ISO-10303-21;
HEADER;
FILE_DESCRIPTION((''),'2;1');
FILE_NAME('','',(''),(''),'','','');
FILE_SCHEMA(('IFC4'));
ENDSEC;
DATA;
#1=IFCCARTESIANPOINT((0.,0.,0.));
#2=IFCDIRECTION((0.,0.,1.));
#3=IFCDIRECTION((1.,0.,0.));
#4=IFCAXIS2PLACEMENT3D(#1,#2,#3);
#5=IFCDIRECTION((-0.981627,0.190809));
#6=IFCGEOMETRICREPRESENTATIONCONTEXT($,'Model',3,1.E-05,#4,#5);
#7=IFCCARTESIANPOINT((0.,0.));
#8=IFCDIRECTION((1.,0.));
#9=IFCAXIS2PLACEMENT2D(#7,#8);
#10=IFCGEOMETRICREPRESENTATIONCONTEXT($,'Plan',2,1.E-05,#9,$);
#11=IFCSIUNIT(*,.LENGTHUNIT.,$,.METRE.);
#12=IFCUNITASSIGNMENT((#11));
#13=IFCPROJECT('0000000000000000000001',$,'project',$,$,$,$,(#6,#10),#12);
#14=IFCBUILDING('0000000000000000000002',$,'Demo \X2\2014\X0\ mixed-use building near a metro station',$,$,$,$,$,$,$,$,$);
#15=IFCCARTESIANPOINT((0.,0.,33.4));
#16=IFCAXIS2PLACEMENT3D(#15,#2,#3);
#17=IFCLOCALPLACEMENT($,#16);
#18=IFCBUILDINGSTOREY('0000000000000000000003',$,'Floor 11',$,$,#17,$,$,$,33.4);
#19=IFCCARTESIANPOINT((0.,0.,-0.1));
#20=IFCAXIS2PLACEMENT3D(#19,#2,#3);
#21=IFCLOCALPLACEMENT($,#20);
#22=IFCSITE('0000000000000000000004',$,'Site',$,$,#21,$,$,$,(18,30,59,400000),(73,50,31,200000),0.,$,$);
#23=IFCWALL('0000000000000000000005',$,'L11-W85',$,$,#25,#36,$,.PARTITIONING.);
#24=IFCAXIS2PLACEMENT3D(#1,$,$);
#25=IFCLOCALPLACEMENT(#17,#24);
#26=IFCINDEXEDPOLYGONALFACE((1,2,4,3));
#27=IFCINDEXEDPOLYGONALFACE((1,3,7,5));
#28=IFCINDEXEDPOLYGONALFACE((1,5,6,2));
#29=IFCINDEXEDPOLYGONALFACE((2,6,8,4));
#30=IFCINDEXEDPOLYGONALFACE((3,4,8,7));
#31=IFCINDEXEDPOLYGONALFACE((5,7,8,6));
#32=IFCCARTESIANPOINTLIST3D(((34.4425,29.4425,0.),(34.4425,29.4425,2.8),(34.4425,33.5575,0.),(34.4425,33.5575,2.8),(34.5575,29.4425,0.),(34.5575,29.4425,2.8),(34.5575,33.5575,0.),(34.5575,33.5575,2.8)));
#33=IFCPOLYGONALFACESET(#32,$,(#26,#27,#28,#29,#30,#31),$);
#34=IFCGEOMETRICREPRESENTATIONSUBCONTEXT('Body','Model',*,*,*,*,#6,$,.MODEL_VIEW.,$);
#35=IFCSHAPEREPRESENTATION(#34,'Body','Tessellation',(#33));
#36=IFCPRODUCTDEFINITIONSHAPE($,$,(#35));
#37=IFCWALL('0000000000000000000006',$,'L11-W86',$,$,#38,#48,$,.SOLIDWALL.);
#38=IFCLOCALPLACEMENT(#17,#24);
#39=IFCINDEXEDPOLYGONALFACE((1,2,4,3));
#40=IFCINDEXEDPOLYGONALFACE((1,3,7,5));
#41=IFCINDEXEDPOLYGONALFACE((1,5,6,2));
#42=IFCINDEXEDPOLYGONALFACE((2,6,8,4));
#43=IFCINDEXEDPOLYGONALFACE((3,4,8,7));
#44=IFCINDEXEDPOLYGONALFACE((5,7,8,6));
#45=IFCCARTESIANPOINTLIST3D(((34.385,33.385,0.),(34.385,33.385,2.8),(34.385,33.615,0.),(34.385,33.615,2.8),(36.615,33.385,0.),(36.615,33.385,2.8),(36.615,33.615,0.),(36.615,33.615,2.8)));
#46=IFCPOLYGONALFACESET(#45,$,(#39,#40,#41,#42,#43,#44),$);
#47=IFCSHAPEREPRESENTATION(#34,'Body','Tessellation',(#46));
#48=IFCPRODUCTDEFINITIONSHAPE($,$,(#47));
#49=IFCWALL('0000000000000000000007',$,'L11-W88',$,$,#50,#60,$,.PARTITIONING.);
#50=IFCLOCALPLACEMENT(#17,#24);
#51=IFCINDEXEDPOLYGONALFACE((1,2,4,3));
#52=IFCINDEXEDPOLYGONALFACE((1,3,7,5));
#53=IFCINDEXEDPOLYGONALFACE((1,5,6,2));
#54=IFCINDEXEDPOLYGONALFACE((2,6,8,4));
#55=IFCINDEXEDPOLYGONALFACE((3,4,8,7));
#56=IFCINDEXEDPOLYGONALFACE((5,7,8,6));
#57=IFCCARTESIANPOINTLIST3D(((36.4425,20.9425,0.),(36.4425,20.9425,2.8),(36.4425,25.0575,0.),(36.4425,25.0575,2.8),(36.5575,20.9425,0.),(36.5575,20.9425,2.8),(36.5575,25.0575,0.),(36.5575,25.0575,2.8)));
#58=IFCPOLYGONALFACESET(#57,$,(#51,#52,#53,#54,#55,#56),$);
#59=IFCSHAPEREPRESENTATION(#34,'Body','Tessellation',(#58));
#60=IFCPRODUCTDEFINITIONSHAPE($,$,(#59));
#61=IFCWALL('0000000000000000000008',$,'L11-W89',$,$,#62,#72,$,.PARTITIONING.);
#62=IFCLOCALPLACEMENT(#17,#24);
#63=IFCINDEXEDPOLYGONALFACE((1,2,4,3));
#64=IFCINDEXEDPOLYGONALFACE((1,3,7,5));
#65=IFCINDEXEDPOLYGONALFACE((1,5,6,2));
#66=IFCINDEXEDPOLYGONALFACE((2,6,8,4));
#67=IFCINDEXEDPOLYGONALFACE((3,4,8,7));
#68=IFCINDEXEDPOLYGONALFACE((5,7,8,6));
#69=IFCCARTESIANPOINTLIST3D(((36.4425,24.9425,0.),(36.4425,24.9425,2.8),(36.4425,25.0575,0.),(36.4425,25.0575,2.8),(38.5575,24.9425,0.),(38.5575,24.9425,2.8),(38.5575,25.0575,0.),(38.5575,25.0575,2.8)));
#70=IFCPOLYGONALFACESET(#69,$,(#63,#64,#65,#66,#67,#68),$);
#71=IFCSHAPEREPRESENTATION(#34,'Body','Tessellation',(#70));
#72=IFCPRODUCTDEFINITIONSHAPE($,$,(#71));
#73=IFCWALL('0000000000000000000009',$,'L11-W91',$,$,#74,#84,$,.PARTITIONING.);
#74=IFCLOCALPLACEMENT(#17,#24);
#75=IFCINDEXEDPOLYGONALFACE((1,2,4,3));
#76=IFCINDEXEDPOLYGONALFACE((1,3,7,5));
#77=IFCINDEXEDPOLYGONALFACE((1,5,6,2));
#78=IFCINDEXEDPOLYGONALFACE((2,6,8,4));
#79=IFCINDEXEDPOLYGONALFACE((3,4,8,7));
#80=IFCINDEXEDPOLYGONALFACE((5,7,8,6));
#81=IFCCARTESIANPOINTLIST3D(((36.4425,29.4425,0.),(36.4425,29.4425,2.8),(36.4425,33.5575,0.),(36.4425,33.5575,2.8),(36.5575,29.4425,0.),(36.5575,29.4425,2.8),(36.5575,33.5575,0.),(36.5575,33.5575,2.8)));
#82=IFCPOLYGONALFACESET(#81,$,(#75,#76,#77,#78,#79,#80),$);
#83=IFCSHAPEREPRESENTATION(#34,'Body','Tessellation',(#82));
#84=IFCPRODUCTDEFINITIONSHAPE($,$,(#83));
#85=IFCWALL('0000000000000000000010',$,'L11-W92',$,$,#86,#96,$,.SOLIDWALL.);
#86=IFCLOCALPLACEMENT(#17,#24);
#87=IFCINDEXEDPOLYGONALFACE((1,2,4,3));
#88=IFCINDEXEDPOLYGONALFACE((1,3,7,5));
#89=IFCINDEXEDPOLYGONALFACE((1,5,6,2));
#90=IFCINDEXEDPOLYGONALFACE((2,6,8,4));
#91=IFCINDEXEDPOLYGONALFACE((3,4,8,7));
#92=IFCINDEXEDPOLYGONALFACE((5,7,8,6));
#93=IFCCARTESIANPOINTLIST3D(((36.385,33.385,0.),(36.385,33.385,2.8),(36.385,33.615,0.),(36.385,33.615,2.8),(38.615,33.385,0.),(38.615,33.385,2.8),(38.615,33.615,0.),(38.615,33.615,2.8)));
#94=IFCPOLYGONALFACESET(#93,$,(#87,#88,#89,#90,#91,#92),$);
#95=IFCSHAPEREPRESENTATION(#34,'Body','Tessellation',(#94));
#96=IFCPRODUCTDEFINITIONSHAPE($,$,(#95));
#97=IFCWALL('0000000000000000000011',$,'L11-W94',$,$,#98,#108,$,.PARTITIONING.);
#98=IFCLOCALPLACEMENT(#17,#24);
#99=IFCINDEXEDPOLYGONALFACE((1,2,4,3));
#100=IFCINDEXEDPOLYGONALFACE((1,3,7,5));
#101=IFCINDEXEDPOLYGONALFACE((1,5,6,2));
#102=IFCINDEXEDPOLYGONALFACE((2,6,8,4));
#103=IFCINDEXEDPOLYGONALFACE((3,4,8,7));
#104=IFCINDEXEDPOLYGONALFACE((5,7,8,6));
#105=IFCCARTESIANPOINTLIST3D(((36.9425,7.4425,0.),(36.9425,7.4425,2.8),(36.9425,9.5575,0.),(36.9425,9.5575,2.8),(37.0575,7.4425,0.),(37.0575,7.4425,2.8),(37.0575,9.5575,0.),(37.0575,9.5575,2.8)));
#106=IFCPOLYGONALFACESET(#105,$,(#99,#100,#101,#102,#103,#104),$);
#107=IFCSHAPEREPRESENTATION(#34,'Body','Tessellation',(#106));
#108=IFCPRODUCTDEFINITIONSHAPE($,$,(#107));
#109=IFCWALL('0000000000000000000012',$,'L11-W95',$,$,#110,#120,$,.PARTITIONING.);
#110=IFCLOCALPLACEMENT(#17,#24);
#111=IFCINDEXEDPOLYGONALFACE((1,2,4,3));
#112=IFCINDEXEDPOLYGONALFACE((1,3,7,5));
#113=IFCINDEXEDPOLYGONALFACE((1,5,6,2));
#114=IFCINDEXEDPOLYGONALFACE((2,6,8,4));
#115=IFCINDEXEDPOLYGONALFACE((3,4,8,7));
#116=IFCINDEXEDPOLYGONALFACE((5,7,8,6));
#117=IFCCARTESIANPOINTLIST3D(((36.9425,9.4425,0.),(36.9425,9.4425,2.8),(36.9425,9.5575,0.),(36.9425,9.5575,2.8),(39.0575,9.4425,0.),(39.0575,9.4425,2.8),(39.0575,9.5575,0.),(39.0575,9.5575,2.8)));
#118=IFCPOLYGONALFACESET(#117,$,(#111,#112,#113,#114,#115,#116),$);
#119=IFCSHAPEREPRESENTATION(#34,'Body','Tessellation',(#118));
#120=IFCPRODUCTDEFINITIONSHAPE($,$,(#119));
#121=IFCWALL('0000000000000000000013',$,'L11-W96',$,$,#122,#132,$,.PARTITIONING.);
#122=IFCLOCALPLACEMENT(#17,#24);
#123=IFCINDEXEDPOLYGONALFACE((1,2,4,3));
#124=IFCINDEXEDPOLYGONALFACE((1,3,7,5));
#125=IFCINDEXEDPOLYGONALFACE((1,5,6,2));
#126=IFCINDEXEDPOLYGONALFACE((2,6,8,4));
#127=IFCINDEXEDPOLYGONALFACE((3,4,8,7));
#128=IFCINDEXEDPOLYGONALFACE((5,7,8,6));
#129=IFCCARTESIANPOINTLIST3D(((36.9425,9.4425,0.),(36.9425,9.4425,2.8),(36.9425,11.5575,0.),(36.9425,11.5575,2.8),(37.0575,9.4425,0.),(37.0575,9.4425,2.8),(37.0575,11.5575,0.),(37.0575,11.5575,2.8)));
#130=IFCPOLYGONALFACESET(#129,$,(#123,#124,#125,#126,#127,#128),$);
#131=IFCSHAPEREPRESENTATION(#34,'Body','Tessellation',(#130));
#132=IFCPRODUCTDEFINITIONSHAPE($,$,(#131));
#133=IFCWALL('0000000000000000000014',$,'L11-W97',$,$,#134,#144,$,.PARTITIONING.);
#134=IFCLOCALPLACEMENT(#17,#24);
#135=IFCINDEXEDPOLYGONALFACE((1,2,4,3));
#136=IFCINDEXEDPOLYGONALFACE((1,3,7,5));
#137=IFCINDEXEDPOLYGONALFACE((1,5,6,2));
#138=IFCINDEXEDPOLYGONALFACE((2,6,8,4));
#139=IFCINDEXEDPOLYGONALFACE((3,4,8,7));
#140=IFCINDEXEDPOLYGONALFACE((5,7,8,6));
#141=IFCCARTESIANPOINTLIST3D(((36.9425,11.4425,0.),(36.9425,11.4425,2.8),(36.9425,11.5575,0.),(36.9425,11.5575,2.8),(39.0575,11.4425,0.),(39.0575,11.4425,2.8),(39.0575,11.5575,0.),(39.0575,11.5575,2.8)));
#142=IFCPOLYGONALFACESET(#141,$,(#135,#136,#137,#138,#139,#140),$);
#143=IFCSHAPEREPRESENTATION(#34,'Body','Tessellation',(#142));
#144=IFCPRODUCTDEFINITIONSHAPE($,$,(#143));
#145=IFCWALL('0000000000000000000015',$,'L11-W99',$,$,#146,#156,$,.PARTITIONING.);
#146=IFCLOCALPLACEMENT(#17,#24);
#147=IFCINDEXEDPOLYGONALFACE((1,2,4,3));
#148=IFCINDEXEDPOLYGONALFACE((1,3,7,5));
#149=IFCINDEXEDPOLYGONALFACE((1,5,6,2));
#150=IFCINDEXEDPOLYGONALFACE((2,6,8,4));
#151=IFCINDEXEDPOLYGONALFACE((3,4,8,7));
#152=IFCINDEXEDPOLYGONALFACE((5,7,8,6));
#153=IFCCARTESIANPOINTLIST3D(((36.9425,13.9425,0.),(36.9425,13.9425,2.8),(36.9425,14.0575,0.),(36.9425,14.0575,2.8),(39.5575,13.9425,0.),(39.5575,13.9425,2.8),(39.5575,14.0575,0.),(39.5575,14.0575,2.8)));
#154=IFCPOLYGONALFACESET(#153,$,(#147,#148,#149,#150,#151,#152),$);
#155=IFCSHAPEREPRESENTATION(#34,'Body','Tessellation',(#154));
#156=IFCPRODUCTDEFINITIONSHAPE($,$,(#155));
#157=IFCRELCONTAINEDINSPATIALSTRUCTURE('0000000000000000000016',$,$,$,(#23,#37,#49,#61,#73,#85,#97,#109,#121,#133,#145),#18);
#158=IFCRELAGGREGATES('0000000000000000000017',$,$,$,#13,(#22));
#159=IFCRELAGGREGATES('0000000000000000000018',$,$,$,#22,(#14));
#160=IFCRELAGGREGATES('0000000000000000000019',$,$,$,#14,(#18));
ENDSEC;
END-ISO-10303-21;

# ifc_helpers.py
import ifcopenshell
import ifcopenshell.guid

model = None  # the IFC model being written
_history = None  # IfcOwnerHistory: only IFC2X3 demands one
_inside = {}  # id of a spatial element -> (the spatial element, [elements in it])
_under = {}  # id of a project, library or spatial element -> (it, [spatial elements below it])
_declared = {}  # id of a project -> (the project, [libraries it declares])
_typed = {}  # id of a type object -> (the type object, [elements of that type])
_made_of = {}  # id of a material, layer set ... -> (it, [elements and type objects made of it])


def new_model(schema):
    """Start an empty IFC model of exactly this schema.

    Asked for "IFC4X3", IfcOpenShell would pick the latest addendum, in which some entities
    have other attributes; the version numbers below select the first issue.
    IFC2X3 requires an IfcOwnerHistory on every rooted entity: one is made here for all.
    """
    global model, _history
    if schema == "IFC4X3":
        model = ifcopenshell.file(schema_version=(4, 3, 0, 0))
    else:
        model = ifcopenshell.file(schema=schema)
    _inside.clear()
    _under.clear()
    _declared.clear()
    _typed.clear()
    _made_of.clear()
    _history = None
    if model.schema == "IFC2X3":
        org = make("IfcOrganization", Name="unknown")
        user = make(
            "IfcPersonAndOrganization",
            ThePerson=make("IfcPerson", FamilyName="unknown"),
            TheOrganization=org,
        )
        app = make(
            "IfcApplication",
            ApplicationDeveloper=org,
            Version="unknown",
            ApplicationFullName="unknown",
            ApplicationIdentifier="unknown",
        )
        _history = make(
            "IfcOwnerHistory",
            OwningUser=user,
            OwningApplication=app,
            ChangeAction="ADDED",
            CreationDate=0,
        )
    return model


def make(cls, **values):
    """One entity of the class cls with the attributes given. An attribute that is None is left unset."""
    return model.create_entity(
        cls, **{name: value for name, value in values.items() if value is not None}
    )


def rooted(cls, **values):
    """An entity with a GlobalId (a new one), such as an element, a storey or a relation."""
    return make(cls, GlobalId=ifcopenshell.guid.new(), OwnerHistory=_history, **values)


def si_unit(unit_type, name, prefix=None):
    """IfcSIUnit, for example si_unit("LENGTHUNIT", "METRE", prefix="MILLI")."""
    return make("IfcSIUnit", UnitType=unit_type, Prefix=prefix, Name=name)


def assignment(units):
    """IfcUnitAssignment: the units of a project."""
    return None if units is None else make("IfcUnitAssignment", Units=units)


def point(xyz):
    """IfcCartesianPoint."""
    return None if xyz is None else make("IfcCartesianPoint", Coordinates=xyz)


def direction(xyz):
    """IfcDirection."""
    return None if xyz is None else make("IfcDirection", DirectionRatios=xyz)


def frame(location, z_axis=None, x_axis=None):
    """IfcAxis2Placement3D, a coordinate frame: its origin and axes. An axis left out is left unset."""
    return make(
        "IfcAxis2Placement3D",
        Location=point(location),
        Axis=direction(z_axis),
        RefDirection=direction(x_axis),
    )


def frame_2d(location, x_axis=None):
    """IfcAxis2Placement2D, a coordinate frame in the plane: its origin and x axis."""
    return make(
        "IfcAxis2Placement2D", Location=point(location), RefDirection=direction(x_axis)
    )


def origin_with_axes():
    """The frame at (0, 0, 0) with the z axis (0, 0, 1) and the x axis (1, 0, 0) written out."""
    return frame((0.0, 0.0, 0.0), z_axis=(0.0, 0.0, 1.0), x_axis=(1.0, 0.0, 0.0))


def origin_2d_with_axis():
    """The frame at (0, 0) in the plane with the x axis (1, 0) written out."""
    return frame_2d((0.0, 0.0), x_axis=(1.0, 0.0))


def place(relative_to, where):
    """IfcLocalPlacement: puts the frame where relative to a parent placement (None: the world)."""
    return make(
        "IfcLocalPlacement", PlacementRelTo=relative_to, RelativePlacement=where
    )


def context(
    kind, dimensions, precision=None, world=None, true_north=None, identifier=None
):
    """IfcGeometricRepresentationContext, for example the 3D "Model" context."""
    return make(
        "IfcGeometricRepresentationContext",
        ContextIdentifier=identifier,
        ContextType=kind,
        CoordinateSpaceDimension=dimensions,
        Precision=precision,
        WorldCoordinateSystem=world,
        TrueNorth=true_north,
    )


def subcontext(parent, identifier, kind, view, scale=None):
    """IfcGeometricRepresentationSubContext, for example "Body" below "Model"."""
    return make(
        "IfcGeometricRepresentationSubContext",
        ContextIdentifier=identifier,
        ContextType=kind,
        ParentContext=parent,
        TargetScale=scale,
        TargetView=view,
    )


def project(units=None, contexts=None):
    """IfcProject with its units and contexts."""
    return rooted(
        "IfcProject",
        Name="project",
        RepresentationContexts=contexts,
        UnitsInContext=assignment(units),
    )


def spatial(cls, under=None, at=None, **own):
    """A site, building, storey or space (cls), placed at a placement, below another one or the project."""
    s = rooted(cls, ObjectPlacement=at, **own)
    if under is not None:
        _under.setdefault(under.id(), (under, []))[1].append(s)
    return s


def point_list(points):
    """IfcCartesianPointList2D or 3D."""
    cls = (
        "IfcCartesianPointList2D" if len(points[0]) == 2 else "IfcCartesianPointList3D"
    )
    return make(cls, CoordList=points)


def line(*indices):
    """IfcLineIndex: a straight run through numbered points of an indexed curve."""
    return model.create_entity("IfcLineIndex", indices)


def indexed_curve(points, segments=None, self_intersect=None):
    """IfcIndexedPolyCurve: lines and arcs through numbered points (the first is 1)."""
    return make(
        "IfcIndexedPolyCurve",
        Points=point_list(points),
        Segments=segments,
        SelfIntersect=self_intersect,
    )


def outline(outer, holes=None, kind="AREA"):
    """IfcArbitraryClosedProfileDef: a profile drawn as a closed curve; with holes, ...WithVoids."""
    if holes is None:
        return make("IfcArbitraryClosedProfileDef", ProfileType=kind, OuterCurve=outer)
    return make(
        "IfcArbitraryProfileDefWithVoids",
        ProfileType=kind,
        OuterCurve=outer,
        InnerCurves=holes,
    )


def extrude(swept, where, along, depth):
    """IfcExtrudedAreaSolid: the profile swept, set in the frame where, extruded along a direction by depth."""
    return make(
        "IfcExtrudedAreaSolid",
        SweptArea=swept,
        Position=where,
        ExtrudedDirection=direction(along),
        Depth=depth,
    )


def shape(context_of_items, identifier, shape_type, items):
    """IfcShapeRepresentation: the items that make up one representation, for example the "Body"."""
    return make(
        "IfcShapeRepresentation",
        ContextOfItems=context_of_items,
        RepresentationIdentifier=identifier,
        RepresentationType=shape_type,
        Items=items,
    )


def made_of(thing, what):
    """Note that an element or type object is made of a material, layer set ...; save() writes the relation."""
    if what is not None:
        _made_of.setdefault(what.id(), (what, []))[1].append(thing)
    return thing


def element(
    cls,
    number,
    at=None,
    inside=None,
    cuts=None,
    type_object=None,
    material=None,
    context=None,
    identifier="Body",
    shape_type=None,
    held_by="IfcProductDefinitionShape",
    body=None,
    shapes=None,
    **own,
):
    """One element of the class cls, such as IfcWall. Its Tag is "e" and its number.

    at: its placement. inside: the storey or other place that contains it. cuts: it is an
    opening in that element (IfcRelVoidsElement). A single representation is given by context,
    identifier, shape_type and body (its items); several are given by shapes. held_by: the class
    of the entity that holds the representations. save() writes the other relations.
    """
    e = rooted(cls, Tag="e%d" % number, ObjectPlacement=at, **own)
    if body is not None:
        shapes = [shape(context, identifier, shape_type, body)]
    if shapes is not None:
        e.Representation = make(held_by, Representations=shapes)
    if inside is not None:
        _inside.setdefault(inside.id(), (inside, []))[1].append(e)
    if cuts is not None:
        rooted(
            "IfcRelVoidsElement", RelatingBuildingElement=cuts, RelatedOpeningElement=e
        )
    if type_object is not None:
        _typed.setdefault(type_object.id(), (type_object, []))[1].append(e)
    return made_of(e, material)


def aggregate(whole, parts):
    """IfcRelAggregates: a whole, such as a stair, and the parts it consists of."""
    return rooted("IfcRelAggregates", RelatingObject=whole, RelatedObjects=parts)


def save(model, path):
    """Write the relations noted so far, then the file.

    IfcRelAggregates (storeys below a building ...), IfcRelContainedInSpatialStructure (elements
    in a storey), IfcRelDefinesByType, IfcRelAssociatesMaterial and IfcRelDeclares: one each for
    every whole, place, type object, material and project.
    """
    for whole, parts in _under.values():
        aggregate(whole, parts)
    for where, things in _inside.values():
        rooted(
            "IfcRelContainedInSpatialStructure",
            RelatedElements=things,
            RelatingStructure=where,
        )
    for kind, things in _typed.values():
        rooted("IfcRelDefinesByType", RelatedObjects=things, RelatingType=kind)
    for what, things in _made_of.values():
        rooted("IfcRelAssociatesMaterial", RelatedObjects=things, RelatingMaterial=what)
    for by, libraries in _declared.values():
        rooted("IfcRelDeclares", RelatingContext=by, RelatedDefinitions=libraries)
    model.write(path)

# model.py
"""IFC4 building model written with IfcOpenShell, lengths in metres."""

from ifc_helpers import new_model, si_unit, direction, frame, origin_with_axes, origin_2d_with_axis, place, context, subcontext, project, spatial, line, indexed_curve, outline, extrude, element, save


model = new_model("IFC4")

# Units and contexts
model_context = context("Model", 3, precision=1e-05, world=origin_with_axes(), true_north=direction((-0.981627, 0.190809)))
plan_context = context("Plan", 2, precision=1e-05, world=origin_2d_with_axis())
body_context = subcontext(model_context, "Body", "Model", "MODEL_VIEW")
ifc_project = project(units=[si_unit("LENGTHUNIT", "METRE")], contexts=[model_context, plan_context])

# Site, building, storey
site_placement = place(None, frame((0.0, 0.0, -0.1), z_axis=(0.0, 0.0, 1.0), x_axis=(1.0, 0.0, 0.0)))
site = spatial("IfcSite", under=ifc_project, at=site_placement, Name="Site", RefLatitude=(18, 30, 59, 400000), RefLongitude=(73, 50, 31, 200000), RefElevation=0.0)
building = spatial("IfcBuilding", under=site, Name="Demo — mixed-use building near a metro station")
storey_placement = place(None, frame((0.0, 0.0, 33.4), z_axis=(0.0, 0.0, 1.0), x_axis=(1.0, 0.0, 0.0)))
storey = spatial("IfcBuildingStorey", under=building, at=storey_placement, Name="Floor 11", Elevation=33.4)

# Walls
wall_1_placement = place(storey_placement, frame((0.0, 0.0, -33.4), z_axis=(0.0, 0.0, 1.0), x_axis=(1.0, 0.0, 0.0)))
element("IfcWall", 1, at=wall_1_placement, inside=storey, Name="L11-W85", PredefinedType="PARTITIONING", context=body_context, shape_type="SweptSolid", body=[
    extrude(outline(indexed_curve([(34.4425, 29.4425), (34.4425, 33.5575), (34.5575, 33.5575), (34.5575, 29.4425)], segments=[line(1, 2, 3, 4, 1)])), frame((0.0, 0.0, 33.4), z_axis=(0.0, 0.0, 1.0), x_axis=(1.0, 0.0, 0.0)), (0.0, 0.0, 1.0), 2.8),
])
wall_2_placement = place(storey_placement, frame((0.0, 0.0, -33.4), z_axis=(0.0, 0.0, 1.0), x_axis=(1.0, 0.0, 0.0)))
element("IfcWall", 2, at=wall_2_placement, inside=storey, Name="L11-W86", PredefinedType="SOLIDWALL", context=body_context, shape_type="SweptSolid", body=[
    extrude(outline(indexed_curve([(36.615, 33.385), (34.385, 33.385), (34.385, 33.615), (36.615, 33.615)], segments=[line(1, 2, 3, 4, 1)])), frame((0.0, 0.0, 33.4), z_axis=(0.0, 0.0, 1.0), x_axis=(1.0, 0.0, 0.0)), (0.0, 0.0, 1.0), 2.8),
])

# Walls
wall_3_placement = place(storey_placement, frame((0.0, 0.0, -33.4), z_axis=(0.0, 0.0, 1.0), x_axis=(1.0, 0.0, 0.0)))
element("IfcWall", 3, at=wall_3_placement, inside=storey, Name="L11-W88", PredefinedType="PARTITIONING", context=body_context, shape_type="SweptSolid", body=[
    extrude(outline(indexed_curve([(36.5575, 25.0575), (36.5575, 20.9425), (36.4425, 20.9425), (36.4425, 25.0575)], segments=[line(1, 2, 3, 4, 1)])), frame((0.0, 0.0, 33.4), z_axis=(0.0, 0.0, 1.0), x_axis=(1.0, 0.0, 0.0)), (0.0, 0.0, 1.0), 2.8),
])
wall_4_placement = place(storey_placement, frame((0.0, 0.0, -33.4), z_axis=(0.0, 0.0, 1.0), x_axis=(1.0, 0.0, 0.0)))
element("IfcWall", 4, at=wall_4_placement, inside=storey, Name="L11-W89", PredefinedType="PARTITIONING", context=body_context, shape_type="SweptSolid", body=[
    extrude(outline(indexed_curve([(38.5575, 24.9425), (36.4425, 24.9425), (36.4425, 25.0575), (38.5575, 25.0575)], segments=[line(1, 2, 3, 4, 1)])), frame((0.0, 0.0, 33.4), z_axis=(0.0, 0.0, 1.0), x_axis=(1.0, 0.0, 0.0)), (0.0, 0.0, 1.0), 2.8),
])

# Walls
wall_5_placement = place(storey_placement, frame((0.0, 0.0, -33.4), z_axis=(0.0, 0.0, 1.0), x_axis=(1.0, 0.0, 0.0)))
element("IfcWall", 5, at=wall_5_placement, inside=storey, Name="L11-W91", PredefinedType="PARTITIONING", context=body_context, shape_type="SweptSolid", body=[
    extrude(outline(indexed_curve([(36.5575, 33.5575), (36.5575, 29.4425), (36.4425, 29.4425), (36.4425, 33.5575)], segments=[line(1, 2, 3, 4, 1)])), frame((0.0, 0.0, 33.4), z_axis=(0.0, 0.0, 1.0), x_axis=(1.0, 0.0, 0.0)), (0.0, 0.0, 1.0), 2.8),
])
wall_6_placement = place(storey_placement, frame((0.0, 0.0, -33.4), z_axis=(0.0, 0.0, 1.0), x_axis=(1.0, 0.0, 0.0)))
element("IfcWall", 6, at=wall_6_placement, inside=storey, Name="L11-W92", PredefinedType="SOLIDWALL", context=body_context, shape_type="SweptSolid", body=[
    extrude(outline(indexed_curve([(38.615, 33.385), (36.385, 33.385), (36.385, 33.615), (38.615, 33.615)], segments=[line(1, 2, 3, 4, 1)])), frame((0.0, 0.0, 33.4), z_axis=(0.0, 0.0, 1.0), x_axis=(1.0, 0.0, 0.0)), (0.0, 0.0, 1.0), 2.8),
])

# Walls
wall_7_placement = place(storey_placement, frame((0.0, 0.0, -33.4), z_axis=(0.0, 0.0, 1.0), x_axis=(1.0, 0.0, 0.0)))
element("IfcWall", 7, at=wall_7_placement, inside=storey, Name="L11-W94", PredefinedType="PARTITIONING", context=body_context, shape_type="SweptSolid", body=[
    extrude(outline(indexed_curve([(37.0575, 9.5575), (37.0575, 7.4425), (36.9425, 7.4425), (36.9425, 9.5575)], segments=[line(1, 2, 3, 4, 1)])), frame((0.0, 0.0, 33.4), z_axis=(0.0, 0.0, 1.0), x_axis=(1.0, 0.0, 0.0)), (0.0, 0.0, 1.0), 2.8),
])
wall_8_placement = place(storey_placement, frame((0.0, 0.0, -33.4), z_axis=(0.0, 0.0, 1.0), x_axis=(1.0, 0.0, 0.0)))
element("IfcWall", 8, at=wall_8_placement, inside=storey, Name="L11-W95", PredefinedType="PARTITIONING", context=body_context, shape_type="SweptSolid", body=[
    extrude(outline(indexed_curve([(39.0575, 9.4425), (36.9425, 9.4425), (36.9425, 9.5575), (39.0575, 9.5575)], segments=[line(1, 2, 3, 4, 1)])), frame((0.0, 0.0, 33.4), z_axis=(0.0, 0.0, 1.0), x_axis=(1.0, 0.0, 0.0)), (0.0, 0.0, 1.0), 2.8),
])
wall_9_placement = place(storey_placement, frame((0.0, 0.0, -33.4), z_axis=(0.0, 0.0, 1.0), x_axis=(1.0, 0.0, 0.0)))
element("IfcWall", 9, at=wall_9_placement, inside=storey, Name="L11-W96", PredefinedType="PARTITIONING", context=body_context, shape_type="SweptSolid", body=[
    extrude(outline(indexed_curve([(37.0575, 11.5575), (37.0575, 9.4425), (36.9425, 9.4425), (36.9425, 11.5575)], segments=[line(1, 2, 3, 4, 1)])), frame((0.0, 0.0, 33.4), z_axis=(0.0, 0.0, 1.0), x_axis=(1.0, 0.0, 0.0)), (0.0, 0.0, 1.0), 2.8),
])
wall_10_placement = place(storey_placement, frame((0.0, 0.0, -33.4), z_axis=(0.0, 0.0, 1.0), x_axis=(1.0, 0.0, 0.0)))
element("IfcWall", 10, at=wall_10_placement, inside=storey, Name="L11-W97", PredefinedType="PARTITIONING", context=body_context, shape_type="SweptSolid", body=[
    extrude(outline(indexed_curve([(36.9425, 11.5575), (39.0575, 11.5575), (39.0575, 11.4425), (36.9425, 11.4425)], segments=[line(1, 2, 3, 4, 1)])), frame((0.0, 0.0, 33.4), z_axis=(0.0, 0.0, 1.0), x_axis=(1.0, 0.0, 0.0)), (0.0, 0.0, 1.0), 2.8),
])

# Wall
wall_11_placement = place(storey_placement, frame((0.0, 0.0, -33.4), z_axis=(0.0, 0.0, 1.0), x_axis=(1.0, 0.0, 0.0)))
element("IfcWall", 11, at=wall_11_placement, inside=storey, Name="L11-W99", PredefinedType="PARTITIONING", context=body_context, shape_type="SweptSolid", body=[
    extrude(outline(indexed_curve([(39.5575, 13.9425), (36.9425, 13.9425), (36.9425, 14.0575), (39.5575, 14.0575)], segments=[line(1, 2, 3, 4, 1)])), frame((0.0, 0.0, 33.4), z_axis=(0.0, 0.0, 1.0), x_axis=(1.0, 0.0, 0.0)), (0.0, 0.0, 1.0), 2.8),
])

save(model, "model.ifc")
